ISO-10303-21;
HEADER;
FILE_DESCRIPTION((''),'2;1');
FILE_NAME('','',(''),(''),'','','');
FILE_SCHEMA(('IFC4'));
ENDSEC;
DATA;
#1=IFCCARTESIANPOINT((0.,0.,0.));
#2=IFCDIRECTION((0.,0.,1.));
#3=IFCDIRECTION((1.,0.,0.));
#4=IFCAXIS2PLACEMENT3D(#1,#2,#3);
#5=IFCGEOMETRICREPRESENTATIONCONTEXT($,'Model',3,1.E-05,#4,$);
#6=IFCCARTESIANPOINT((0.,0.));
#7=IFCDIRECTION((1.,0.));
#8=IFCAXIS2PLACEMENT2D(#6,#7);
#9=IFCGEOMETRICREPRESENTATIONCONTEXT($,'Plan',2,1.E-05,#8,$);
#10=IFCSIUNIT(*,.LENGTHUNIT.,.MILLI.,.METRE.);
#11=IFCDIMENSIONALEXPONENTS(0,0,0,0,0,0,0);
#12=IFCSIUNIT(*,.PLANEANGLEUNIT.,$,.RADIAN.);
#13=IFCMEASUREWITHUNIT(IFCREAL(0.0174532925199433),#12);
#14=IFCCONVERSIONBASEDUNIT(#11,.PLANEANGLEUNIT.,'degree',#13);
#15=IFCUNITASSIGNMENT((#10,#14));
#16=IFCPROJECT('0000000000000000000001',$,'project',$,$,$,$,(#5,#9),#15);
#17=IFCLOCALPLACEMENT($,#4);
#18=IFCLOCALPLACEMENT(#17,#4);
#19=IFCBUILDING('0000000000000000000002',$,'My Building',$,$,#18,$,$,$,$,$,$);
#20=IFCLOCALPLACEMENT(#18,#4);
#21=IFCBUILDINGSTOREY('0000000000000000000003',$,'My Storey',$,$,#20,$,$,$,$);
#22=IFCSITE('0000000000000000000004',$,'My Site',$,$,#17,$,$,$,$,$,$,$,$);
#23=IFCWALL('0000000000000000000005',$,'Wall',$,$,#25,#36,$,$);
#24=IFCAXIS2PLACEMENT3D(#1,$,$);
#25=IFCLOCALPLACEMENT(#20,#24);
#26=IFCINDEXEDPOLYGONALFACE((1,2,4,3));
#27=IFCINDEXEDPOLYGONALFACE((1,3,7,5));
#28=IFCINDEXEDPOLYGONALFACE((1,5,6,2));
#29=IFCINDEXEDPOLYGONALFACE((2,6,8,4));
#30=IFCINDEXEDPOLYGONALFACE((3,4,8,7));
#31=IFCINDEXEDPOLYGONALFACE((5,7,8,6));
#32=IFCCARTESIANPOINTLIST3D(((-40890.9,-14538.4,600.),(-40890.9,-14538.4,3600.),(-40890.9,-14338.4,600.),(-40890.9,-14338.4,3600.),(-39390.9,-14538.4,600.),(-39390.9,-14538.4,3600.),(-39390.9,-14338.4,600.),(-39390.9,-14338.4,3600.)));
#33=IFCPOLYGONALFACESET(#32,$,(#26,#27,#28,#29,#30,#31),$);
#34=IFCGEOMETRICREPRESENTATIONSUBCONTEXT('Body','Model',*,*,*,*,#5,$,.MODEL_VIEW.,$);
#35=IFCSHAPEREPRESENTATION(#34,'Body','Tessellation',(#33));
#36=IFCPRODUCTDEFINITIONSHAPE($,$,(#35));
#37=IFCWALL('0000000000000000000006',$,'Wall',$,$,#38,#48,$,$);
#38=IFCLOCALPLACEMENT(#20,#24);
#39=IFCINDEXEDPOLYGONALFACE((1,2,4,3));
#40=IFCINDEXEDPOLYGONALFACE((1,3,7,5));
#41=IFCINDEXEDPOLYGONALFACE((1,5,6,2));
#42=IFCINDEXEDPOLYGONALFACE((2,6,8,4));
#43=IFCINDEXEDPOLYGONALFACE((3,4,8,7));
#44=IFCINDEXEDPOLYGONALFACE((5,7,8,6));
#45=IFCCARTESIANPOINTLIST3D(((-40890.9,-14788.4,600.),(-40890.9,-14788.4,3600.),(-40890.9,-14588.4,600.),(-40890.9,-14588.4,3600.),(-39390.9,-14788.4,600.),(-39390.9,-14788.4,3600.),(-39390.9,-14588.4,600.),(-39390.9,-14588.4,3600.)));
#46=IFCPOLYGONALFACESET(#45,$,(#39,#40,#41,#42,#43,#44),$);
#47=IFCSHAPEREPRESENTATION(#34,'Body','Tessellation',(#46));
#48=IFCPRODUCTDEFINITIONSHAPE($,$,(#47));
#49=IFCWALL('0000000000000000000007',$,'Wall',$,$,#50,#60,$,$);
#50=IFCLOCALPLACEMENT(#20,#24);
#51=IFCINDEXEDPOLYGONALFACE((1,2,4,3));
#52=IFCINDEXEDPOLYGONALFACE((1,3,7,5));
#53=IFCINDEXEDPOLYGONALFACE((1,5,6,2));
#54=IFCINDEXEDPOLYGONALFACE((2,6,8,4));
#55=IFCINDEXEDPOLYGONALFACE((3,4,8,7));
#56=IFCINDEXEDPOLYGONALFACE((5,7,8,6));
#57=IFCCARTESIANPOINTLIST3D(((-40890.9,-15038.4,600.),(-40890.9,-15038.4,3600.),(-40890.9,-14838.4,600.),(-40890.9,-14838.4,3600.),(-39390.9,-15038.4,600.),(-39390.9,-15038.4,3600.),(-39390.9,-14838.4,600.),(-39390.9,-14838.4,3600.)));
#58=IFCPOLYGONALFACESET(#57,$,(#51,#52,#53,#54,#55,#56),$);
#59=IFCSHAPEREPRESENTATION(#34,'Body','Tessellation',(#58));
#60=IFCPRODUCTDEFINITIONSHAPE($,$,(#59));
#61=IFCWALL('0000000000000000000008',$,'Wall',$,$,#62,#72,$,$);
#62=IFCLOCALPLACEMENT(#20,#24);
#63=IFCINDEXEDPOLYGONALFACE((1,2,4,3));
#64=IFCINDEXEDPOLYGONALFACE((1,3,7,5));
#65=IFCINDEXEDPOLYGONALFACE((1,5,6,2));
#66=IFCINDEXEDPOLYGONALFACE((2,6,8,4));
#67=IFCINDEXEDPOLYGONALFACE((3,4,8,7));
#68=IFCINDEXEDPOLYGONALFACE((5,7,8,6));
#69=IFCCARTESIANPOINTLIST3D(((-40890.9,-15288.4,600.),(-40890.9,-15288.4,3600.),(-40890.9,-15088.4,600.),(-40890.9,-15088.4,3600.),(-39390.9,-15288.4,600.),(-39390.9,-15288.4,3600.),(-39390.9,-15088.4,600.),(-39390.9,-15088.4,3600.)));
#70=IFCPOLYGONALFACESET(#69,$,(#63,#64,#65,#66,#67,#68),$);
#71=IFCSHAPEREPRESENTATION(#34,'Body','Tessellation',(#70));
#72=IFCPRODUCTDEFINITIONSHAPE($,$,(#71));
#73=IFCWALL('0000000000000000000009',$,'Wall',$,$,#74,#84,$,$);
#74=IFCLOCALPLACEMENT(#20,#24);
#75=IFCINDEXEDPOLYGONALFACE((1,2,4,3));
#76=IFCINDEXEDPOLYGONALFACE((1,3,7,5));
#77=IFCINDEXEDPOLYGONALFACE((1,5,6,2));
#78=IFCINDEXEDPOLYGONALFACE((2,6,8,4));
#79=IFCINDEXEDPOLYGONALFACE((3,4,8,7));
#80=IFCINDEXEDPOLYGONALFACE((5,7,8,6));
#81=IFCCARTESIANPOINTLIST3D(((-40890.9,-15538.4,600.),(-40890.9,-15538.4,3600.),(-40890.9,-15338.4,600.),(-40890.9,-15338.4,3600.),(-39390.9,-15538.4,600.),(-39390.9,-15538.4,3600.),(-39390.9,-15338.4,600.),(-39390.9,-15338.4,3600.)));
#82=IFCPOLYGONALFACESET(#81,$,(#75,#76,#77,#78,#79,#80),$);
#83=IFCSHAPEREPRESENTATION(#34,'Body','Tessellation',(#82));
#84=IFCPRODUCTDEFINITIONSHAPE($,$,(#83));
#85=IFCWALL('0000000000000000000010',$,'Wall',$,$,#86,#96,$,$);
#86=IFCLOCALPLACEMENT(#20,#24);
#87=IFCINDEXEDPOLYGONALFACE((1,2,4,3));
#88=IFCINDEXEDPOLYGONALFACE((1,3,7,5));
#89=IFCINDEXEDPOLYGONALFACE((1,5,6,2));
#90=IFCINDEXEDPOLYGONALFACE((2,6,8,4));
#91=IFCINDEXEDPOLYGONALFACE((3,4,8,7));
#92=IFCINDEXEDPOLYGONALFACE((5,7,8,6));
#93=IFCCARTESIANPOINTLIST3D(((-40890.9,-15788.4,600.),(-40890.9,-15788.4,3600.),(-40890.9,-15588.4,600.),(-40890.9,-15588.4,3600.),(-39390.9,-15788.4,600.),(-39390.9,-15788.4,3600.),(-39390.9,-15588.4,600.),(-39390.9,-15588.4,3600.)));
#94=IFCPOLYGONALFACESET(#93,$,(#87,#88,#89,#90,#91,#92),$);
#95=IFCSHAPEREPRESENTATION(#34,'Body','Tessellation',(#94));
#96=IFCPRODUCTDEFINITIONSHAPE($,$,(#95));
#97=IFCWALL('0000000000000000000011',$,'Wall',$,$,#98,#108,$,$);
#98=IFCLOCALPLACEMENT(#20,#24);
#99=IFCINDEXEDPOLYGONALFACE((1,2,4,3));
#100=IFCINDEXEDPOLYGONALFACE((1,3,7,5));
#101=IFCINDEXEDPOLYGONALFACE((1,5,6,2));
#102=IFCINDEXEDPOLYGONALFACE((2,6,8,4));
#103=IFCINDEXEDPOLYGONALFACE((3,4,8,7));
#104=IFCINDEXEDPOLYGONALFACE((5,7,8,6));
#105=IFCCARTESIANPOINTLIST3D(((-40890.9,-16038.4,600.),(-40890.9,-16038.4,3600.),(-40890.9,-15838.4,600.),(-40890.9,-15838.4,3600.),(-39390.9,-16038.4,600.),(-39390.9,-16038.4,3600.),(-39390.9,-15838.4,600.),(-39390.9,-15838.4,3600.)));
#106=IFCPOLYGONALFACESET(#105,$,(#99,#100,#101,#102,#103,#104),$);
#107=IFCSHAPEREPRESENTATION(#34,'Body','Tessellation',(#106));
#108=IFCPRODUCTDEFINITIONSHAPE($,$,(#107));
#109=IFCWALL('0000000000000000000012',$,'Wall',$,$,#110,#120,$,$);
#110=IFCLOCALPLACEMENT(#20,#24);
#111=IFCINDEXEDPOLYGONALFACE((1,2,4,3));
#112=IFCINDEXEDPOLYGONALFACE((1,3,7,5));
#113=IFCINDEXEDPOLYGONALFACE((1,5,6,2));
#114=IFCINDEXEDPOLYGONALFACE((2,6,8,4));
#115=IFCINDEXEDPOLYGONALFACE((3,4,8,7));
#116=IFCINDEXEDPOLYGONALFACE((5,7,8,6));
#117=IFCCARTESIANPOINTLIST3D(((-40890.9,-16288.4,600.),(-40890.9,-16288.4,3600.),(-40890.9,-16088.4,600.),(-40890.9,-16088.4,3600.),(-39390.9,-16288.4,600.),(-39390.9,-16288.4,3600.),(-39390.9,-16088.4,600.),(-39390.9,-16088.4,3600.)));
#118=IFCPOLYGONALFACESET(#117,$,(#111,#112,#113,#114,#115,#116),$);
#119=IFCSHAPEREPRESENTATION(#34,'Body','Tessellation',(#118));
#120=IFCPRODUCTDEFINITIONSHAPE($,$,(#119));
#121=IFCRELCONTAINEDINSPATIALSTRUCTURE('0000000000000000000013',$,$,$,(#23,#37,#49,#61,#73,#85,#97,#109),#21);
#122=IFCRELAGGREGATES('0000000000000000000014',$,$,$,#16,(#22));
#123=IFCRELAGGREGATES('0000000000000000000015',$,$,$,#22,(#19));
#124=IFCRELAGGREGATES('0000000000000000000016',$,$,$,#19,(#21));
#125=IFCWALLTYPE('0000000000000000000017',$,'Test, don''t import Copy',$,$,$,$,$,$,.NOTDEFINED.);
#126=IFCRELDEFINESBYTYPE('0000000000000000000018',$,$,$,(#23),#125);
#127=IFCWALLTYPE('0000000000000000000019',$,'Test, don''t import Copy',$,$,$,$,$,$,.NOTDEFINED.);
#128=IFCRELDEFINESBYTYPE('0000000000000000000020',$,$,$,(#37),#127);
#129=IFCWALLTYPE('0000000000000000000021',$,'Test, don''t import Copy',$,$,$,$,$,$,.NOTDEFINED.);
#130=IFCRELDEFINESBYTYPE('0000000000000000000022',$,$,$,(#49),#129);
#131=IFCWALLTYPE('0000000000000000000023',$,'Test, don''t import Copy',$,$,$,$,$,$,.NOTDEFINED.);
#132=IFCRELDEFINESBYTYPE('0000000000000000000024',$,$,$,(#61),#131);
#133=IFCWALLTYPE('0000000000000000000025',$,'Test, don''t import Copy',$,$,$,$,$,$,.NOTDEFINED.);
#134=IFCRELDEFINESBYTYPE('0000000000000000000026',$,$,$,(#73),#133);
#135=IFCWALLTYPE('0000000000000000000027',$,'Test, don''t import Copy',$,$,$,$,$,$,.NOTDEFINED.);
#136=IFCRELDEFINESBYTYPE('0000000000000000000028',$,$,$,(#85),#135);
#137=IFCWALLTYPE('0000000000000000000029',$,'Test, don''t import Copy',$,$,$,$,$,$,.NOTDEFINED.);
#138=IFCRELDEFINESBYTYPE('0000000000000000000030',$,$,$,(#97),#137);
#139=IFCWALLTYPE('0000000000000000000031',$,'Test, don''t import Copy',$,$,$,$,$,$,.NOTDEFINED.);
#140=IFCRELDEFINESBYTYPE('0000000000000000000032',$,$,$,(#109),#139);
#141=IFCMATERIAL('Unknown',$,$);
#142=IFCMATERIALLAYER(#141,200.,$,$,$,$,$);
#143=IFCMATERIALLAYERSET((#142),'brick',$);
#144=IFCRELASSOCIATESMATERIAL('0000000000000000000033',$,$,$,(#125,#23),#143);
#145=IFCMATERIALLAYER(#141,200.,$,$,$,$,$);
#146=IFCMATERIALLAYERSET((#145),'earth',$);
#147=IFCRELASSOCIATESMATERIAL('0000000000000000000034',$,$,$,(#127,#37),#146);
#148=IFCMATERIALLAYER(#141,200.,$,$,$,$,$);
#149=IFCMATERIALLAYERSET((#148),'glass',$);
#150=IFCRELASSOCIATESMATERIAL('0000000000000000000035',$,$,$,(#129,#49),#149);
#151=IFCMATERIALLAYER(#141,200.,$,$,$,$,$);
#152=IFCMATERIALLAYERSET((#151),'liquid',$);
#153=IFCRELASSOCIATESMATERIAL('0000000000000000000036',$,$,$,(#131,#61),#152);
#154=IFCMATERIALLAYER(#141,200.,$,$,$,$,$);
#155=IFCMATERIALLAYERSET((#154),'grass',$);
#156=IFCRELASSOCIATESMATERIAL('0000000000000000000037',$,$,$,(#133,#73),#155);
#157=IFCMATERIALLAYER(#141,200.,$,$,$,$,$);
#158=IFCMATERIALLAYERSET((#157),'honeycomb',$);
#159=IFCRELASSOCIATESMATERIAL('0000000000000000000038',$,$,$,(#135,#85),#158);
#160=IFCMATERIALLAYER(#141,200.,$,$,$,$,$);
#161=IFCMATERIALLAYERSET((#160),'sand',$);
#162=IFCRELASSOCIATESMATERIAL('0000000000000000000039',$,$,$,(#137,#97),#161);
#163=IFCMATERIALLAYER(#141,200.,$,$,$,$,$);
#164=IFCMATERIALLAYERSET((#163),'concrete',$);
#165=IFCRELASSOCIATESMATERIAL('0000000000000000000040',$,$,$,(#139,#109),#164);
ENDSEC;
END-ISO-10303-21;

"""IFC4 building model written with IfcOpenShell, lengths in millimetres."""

from ifc_helpers import new_model, entity, si_unit, converted_unit, frame, origin_with_axes, origin_2d_with_axis, place, context, subcontext, project, spatial, indexed_curve, outline, extrude, material, layer, layer_set, layer_usage, type_object, element, save


model = new_model("IFC4")

# Units and contexts
model_context = context("Model", 3, precision=1e-05, world=origin_with_axes())
plan_context = context("Plan", 2, precision=1e-05, world=origin_2d_with_axis())
body_context = subcontext(model_context, "Body", "Model", "MODEL_VIEW")
ifc_project = project(units=[si_unit("LENGTHUNIT", "METRE", prefix="MILLI"), converted_unit("PLANEANGLEUNIT", "degree", entity("IfcReal", 0.0174532925199433), si_unit("PLANEANGLEUNIT", "RADIAN"), dimensions=[0, 0, 0, 0, 0, 0, 0])], contexts=[model_context, plan_context])

# Site, building, storey
site_placement = place(None, origin_with_axes())
site = spatial("IfcSite", under=ifc_project, at=site_placement, Name="My Site")
building_placement = place(site_placement, origin_with_axes())
building = spatial("IfcBuilding", under=site, at=building_placement, Name="My Building")
storey_placement = place(building_placement, origin_with_axes())
storey = spatial("IfcBuildingStorey", under=building, at=storey_placement, Name="My Storey")

# Walls
ifc_material_1 = material(Name="Unknown")
ifc_layer_1 = layer(ifc_material_1, 200.0)
ifc_layer_set_1 = layer_set([ifc_layer_1], Name="brick")
ifc_layer_usage_1 = layer_usage(ifc_layer_set_1, "AXIS2", "POSITIVE", 0.0)
wall_type_1 = type_object("IfcWallType", Name="Test, don't import Copy", PredefinedType="NOTDEFINED", material=ifc_layer_set_1)
wall_1_placement = place(storey_placement, frame((-40890.9, -14538.4, 600.0), z_axis=(0.0, 0.0, 1.0), x_axis=(1.0, 0.0, 0.0)))
element("IfcWall", 1, at=wall_1_placement, inside=storey, type_object=wall_type_1, material=ifc_layer_usage_1, Name="Wall", context=body_context, shape_type="SweptSolid", body=[
    extrude(outline(indexed_curve([(0.0, 0.0), (0.0, 200.0), (1500.0, 200.0), (1500.0, 0.0), (0.0, 0.0)], self_intersect=False)), origin_with_axes(), (0.0, 0.0, 1.0), 3000.0),
])
ifc_layer_2 = layer(ifc_material_1, 200.0)
ifc_layer_set_2 = layer_set([ifc_layer_2], Name="earth")
ifc_layer_usage_2 = layer_usage(ifc_layer_set_2, "AXIS2", "POSITIVE", 0.0)
wall_type_2 = type_object("IfcWallType", Name="Test, don't import Copy", PredefinedType="NOTDEFINED", material=ifc_layer_set_2)
wall_2_placement = place(storey_placement, frame((-40890.9, -14788.4, 600.0), z_axis=(0.0, 0.0, 1.0), x_axis=(1.0, 0.0, 0.0)))
element("IfcWall", 2, at=wall_2_placement, inside=storey, type_object=wall_type_2, material=ifc_layer_usage_2, Name="Wall", context=body_context, shape_type="SweptSolid", body=[
    extrude(outline(indexed_curve([(0.0, 0.0), (0.0, 200.0), (1500.0, 200.0), (1500.0, 0.0), (0.0, 0.0)], self_intersect=False)), origin_with_axes(), (0.0, 0.0, 1.0), 3000.0),
])
ifc_layer_3 = layer(ifc_material_1, 200.0)
ifc_layer_set_3 = layer_set([ifc_layer_3], Name="glass")
ifc_layer_usage_3 = layer_usage(ifc_layer_set_3, "AXIS2", "POSITIVE", 0.0)
wall_type_3 = type_object("IfcWallType", Name="Test, don't import Copy", PredefinedType="NOTDEFINED", material=ifc_layer_set_3)
wall_3_placement = place(storey_placement, frame((-40890.9, -15038.4, 600.0), z_axis=(0.0, 0.0, 1.0), x_axis=(1.0, 0.0, 0.0)))
element("IfcWall", 3, at=wall_3_placement, inside=storey, type_object=wall_type_3, material=ifc_layer_usage_3, Name="Wall", context=body_context, shape_type="SweptSolid", body=[
    extrude(outline(indexed_curve([(0.0, 0.0), (0.0, 200.0), (1500.0, 200.0), (1500.0, 0.0), (0.0, 0.0)], self_intersect=False)), origin_with_axes(), (0.0, 0.0, 1.0), 3000.0),
])
ifc_layer_4 = layer(ifc_material_1, 200.0)
ifc_layer_set_4 = layer_set([ifc_layer_4], Name="liquid")
ifc_layer_usage_4 = layer_usage(ifc_layer_set_4, "AXIS2", "POSITIVE", 0.0)
wall_type_4 = type_object("IfcWallType", Name="Test, don't import Copy", PredefinedType="NOTDEFINED", material=ifc_layer_set_4)
wall_4_placement = place(storey_placement, frame((-40890.9, -15288.4, 600.0), z_axis=(0.0, 0.0, 1.0), x_axis=(1.0, 0.0, 0.0)))
element("IfcWall", 4, at=wall_4_placement, inside=storey, type_object=wall_type_4, material=ifc_layer_usage_4, Name="Wall", context=body_context, shape_type="SweptSolid", body=[
    extrude(outline(indexed_curve([(0.0, 0.0), (0.0, 200.0), (1500.0, 200.0), (1500.0, 0.0), (0.0, 0.0)], self_intersect=False)), origin_with_axes(), (0.0, 0.0, 1.0), 3000.0),
])
ifc_layer_5 = layer(ifc_material_1, 200.0)
ifc_layer_set_5 = layer_set([ifc_layer_5], Name="grass")
ifc_layer_usage_5 = layer_usage(ifc_layer_set_5, "AXIS2", "POSITIVE", 0.0)
wall_type_5 = type_object("IfcWallType", Name="Test, don't import Copy", PredefinedType="NOTDEFINED", material=ifc_layer_set_5)
wall_5_placement = place(storey_placement, frame((-40890.9, -15538.4, 600.0), z_axis=(0.0, 0.0, 1.0), x_axis=(1.0, 0.0, 0.0)))
element("IfcWall", 5, at=wall_5_placement, inside=storey, type_object=wall_type_5, material=ifc_layer_usage_5, Name="Wall", context=body_context, shape_type="SweptSolid", body=[
    extrude(outline(indexed_curve([(0.0, 0.0), (0.0, 200.0), (1500.0, 200.0), (1500.0, 0.0), (0.0, 0.0)], self_intersect=False)), origin_with_axes(), (0.0, 0.0, 1.0), 3000.0),
])
ifc_layer_6 = layer(ifc_material_1, 200.0)
ifc_layer_set_6 = layer_set([ifc_layer_6], Name="honeycomb")
ifc_layer_usage_6 = layer_usage(ifc_layer_set_6, "AXIS2", "POSITIVE", 0.0)
wall_type_6 = type_object("IfcWallType", Name="Test, don't import Copy", PredefinedType="NOTDEFINED", material=ifc_layer_set_6)
wall_6_placement = place(storey_placement, frame((-40890.9, -15788.4, 600.0), z_axis=(0.0, 0.0, 1.0), x_axis=(1.0, 0.0, 0.0)))
element("IfcWall", 6, at=wall_6_placement, inside=storey, type_object=wall_type_6, material=ifc_layer_usage_6, Name="Wall", context=body_context, shape_type="SweptSolid", body=[
    extrude(outline(indexed_curve([(0.0, 0.0), (0.0, 200.0), (1500.0, 200.0), (1500.0, 0.0), (0.0, 0.0)], self_intersect=False)), origin_with_axes(), (0.0, 0.0, 1.0), 3000.0),
])
ifc_layer_7 = layer(ifc_material_1, 200.0)
ifc_layer_set_7 = layer_set([ifc_layer_7], Name="sand")
ifc_layer_usage_7 = layer_usage(ifc_layer_set_7, "AXIS2", "POSITIVE", 0.0)
wall_type_7 = type_object("IfcWallType", Name="Test, don't import Copy", PredefinedType="NOTDEFINED", material=ifc_layer_set_7)
wall_7_placement = place(storey_placement, frame((-40890.9, -16038.4, 600.0), z_axis=(0.0, 0.0, 1.0), x_axis=(1.0, 0.0, 0.0)))
element("IfcWall", 7, at=wall_7_placement, inside=storey, type_object=wall_type_7, material=ifc_layer_usage_7, Name="Wall", context=body_context, shape_type="SweptSolid", body=[
    extrude(outline(indexed_curve([(0.0, 0.0), (0.0, 200.0), (1500.0, 200.0), (1500.0, 0.0), (0.0, 0.0)], self_intersect=False)), origin_with_axes(), (0.0, 0.0, 1.0), 3000.0),
])
ifc_layer_8 = layer(ifc_material_1, 200.0)
ifc_layer_set_8 = layer_set([ifc_layer_8], Name="concrete")
ifc_layer_usage_8 = layer_usage(ifc_layer_set_8, "AXIS2", "POSITIVE", 0.0)
wall_type_8 = type_object("IfcWallType", Name="Test, don't import Copy", PredefinedType="NOTDEFINED", material=ifc_layer_set_8)
wall_8_placement = place(storey_placement, frame((-40890.9, -16288.4, 600.0), z_axis=(0.0, 0.0, 1.0), x_axis=(1.0, 0.0, 0.0)))
element("IfcWall", 8, at=wall_8_placement, inside=storey, type_object=wall_type_8, material=ifc_layer_usage_8, Name="Wall", context=body_context, shape_type="SweptSolid", body=[
    extrude(outline(indexed_curve([(0.0, 0.0), (0.0, 200.0), (1500.0, 200.0), (1500.0, 0.0), (0.0, 0.0)], self_intersect=False)), origin_with_axes(), (0.0, 0.0, 1.0), 3000.0),
])

save(model, "model.ifc")
